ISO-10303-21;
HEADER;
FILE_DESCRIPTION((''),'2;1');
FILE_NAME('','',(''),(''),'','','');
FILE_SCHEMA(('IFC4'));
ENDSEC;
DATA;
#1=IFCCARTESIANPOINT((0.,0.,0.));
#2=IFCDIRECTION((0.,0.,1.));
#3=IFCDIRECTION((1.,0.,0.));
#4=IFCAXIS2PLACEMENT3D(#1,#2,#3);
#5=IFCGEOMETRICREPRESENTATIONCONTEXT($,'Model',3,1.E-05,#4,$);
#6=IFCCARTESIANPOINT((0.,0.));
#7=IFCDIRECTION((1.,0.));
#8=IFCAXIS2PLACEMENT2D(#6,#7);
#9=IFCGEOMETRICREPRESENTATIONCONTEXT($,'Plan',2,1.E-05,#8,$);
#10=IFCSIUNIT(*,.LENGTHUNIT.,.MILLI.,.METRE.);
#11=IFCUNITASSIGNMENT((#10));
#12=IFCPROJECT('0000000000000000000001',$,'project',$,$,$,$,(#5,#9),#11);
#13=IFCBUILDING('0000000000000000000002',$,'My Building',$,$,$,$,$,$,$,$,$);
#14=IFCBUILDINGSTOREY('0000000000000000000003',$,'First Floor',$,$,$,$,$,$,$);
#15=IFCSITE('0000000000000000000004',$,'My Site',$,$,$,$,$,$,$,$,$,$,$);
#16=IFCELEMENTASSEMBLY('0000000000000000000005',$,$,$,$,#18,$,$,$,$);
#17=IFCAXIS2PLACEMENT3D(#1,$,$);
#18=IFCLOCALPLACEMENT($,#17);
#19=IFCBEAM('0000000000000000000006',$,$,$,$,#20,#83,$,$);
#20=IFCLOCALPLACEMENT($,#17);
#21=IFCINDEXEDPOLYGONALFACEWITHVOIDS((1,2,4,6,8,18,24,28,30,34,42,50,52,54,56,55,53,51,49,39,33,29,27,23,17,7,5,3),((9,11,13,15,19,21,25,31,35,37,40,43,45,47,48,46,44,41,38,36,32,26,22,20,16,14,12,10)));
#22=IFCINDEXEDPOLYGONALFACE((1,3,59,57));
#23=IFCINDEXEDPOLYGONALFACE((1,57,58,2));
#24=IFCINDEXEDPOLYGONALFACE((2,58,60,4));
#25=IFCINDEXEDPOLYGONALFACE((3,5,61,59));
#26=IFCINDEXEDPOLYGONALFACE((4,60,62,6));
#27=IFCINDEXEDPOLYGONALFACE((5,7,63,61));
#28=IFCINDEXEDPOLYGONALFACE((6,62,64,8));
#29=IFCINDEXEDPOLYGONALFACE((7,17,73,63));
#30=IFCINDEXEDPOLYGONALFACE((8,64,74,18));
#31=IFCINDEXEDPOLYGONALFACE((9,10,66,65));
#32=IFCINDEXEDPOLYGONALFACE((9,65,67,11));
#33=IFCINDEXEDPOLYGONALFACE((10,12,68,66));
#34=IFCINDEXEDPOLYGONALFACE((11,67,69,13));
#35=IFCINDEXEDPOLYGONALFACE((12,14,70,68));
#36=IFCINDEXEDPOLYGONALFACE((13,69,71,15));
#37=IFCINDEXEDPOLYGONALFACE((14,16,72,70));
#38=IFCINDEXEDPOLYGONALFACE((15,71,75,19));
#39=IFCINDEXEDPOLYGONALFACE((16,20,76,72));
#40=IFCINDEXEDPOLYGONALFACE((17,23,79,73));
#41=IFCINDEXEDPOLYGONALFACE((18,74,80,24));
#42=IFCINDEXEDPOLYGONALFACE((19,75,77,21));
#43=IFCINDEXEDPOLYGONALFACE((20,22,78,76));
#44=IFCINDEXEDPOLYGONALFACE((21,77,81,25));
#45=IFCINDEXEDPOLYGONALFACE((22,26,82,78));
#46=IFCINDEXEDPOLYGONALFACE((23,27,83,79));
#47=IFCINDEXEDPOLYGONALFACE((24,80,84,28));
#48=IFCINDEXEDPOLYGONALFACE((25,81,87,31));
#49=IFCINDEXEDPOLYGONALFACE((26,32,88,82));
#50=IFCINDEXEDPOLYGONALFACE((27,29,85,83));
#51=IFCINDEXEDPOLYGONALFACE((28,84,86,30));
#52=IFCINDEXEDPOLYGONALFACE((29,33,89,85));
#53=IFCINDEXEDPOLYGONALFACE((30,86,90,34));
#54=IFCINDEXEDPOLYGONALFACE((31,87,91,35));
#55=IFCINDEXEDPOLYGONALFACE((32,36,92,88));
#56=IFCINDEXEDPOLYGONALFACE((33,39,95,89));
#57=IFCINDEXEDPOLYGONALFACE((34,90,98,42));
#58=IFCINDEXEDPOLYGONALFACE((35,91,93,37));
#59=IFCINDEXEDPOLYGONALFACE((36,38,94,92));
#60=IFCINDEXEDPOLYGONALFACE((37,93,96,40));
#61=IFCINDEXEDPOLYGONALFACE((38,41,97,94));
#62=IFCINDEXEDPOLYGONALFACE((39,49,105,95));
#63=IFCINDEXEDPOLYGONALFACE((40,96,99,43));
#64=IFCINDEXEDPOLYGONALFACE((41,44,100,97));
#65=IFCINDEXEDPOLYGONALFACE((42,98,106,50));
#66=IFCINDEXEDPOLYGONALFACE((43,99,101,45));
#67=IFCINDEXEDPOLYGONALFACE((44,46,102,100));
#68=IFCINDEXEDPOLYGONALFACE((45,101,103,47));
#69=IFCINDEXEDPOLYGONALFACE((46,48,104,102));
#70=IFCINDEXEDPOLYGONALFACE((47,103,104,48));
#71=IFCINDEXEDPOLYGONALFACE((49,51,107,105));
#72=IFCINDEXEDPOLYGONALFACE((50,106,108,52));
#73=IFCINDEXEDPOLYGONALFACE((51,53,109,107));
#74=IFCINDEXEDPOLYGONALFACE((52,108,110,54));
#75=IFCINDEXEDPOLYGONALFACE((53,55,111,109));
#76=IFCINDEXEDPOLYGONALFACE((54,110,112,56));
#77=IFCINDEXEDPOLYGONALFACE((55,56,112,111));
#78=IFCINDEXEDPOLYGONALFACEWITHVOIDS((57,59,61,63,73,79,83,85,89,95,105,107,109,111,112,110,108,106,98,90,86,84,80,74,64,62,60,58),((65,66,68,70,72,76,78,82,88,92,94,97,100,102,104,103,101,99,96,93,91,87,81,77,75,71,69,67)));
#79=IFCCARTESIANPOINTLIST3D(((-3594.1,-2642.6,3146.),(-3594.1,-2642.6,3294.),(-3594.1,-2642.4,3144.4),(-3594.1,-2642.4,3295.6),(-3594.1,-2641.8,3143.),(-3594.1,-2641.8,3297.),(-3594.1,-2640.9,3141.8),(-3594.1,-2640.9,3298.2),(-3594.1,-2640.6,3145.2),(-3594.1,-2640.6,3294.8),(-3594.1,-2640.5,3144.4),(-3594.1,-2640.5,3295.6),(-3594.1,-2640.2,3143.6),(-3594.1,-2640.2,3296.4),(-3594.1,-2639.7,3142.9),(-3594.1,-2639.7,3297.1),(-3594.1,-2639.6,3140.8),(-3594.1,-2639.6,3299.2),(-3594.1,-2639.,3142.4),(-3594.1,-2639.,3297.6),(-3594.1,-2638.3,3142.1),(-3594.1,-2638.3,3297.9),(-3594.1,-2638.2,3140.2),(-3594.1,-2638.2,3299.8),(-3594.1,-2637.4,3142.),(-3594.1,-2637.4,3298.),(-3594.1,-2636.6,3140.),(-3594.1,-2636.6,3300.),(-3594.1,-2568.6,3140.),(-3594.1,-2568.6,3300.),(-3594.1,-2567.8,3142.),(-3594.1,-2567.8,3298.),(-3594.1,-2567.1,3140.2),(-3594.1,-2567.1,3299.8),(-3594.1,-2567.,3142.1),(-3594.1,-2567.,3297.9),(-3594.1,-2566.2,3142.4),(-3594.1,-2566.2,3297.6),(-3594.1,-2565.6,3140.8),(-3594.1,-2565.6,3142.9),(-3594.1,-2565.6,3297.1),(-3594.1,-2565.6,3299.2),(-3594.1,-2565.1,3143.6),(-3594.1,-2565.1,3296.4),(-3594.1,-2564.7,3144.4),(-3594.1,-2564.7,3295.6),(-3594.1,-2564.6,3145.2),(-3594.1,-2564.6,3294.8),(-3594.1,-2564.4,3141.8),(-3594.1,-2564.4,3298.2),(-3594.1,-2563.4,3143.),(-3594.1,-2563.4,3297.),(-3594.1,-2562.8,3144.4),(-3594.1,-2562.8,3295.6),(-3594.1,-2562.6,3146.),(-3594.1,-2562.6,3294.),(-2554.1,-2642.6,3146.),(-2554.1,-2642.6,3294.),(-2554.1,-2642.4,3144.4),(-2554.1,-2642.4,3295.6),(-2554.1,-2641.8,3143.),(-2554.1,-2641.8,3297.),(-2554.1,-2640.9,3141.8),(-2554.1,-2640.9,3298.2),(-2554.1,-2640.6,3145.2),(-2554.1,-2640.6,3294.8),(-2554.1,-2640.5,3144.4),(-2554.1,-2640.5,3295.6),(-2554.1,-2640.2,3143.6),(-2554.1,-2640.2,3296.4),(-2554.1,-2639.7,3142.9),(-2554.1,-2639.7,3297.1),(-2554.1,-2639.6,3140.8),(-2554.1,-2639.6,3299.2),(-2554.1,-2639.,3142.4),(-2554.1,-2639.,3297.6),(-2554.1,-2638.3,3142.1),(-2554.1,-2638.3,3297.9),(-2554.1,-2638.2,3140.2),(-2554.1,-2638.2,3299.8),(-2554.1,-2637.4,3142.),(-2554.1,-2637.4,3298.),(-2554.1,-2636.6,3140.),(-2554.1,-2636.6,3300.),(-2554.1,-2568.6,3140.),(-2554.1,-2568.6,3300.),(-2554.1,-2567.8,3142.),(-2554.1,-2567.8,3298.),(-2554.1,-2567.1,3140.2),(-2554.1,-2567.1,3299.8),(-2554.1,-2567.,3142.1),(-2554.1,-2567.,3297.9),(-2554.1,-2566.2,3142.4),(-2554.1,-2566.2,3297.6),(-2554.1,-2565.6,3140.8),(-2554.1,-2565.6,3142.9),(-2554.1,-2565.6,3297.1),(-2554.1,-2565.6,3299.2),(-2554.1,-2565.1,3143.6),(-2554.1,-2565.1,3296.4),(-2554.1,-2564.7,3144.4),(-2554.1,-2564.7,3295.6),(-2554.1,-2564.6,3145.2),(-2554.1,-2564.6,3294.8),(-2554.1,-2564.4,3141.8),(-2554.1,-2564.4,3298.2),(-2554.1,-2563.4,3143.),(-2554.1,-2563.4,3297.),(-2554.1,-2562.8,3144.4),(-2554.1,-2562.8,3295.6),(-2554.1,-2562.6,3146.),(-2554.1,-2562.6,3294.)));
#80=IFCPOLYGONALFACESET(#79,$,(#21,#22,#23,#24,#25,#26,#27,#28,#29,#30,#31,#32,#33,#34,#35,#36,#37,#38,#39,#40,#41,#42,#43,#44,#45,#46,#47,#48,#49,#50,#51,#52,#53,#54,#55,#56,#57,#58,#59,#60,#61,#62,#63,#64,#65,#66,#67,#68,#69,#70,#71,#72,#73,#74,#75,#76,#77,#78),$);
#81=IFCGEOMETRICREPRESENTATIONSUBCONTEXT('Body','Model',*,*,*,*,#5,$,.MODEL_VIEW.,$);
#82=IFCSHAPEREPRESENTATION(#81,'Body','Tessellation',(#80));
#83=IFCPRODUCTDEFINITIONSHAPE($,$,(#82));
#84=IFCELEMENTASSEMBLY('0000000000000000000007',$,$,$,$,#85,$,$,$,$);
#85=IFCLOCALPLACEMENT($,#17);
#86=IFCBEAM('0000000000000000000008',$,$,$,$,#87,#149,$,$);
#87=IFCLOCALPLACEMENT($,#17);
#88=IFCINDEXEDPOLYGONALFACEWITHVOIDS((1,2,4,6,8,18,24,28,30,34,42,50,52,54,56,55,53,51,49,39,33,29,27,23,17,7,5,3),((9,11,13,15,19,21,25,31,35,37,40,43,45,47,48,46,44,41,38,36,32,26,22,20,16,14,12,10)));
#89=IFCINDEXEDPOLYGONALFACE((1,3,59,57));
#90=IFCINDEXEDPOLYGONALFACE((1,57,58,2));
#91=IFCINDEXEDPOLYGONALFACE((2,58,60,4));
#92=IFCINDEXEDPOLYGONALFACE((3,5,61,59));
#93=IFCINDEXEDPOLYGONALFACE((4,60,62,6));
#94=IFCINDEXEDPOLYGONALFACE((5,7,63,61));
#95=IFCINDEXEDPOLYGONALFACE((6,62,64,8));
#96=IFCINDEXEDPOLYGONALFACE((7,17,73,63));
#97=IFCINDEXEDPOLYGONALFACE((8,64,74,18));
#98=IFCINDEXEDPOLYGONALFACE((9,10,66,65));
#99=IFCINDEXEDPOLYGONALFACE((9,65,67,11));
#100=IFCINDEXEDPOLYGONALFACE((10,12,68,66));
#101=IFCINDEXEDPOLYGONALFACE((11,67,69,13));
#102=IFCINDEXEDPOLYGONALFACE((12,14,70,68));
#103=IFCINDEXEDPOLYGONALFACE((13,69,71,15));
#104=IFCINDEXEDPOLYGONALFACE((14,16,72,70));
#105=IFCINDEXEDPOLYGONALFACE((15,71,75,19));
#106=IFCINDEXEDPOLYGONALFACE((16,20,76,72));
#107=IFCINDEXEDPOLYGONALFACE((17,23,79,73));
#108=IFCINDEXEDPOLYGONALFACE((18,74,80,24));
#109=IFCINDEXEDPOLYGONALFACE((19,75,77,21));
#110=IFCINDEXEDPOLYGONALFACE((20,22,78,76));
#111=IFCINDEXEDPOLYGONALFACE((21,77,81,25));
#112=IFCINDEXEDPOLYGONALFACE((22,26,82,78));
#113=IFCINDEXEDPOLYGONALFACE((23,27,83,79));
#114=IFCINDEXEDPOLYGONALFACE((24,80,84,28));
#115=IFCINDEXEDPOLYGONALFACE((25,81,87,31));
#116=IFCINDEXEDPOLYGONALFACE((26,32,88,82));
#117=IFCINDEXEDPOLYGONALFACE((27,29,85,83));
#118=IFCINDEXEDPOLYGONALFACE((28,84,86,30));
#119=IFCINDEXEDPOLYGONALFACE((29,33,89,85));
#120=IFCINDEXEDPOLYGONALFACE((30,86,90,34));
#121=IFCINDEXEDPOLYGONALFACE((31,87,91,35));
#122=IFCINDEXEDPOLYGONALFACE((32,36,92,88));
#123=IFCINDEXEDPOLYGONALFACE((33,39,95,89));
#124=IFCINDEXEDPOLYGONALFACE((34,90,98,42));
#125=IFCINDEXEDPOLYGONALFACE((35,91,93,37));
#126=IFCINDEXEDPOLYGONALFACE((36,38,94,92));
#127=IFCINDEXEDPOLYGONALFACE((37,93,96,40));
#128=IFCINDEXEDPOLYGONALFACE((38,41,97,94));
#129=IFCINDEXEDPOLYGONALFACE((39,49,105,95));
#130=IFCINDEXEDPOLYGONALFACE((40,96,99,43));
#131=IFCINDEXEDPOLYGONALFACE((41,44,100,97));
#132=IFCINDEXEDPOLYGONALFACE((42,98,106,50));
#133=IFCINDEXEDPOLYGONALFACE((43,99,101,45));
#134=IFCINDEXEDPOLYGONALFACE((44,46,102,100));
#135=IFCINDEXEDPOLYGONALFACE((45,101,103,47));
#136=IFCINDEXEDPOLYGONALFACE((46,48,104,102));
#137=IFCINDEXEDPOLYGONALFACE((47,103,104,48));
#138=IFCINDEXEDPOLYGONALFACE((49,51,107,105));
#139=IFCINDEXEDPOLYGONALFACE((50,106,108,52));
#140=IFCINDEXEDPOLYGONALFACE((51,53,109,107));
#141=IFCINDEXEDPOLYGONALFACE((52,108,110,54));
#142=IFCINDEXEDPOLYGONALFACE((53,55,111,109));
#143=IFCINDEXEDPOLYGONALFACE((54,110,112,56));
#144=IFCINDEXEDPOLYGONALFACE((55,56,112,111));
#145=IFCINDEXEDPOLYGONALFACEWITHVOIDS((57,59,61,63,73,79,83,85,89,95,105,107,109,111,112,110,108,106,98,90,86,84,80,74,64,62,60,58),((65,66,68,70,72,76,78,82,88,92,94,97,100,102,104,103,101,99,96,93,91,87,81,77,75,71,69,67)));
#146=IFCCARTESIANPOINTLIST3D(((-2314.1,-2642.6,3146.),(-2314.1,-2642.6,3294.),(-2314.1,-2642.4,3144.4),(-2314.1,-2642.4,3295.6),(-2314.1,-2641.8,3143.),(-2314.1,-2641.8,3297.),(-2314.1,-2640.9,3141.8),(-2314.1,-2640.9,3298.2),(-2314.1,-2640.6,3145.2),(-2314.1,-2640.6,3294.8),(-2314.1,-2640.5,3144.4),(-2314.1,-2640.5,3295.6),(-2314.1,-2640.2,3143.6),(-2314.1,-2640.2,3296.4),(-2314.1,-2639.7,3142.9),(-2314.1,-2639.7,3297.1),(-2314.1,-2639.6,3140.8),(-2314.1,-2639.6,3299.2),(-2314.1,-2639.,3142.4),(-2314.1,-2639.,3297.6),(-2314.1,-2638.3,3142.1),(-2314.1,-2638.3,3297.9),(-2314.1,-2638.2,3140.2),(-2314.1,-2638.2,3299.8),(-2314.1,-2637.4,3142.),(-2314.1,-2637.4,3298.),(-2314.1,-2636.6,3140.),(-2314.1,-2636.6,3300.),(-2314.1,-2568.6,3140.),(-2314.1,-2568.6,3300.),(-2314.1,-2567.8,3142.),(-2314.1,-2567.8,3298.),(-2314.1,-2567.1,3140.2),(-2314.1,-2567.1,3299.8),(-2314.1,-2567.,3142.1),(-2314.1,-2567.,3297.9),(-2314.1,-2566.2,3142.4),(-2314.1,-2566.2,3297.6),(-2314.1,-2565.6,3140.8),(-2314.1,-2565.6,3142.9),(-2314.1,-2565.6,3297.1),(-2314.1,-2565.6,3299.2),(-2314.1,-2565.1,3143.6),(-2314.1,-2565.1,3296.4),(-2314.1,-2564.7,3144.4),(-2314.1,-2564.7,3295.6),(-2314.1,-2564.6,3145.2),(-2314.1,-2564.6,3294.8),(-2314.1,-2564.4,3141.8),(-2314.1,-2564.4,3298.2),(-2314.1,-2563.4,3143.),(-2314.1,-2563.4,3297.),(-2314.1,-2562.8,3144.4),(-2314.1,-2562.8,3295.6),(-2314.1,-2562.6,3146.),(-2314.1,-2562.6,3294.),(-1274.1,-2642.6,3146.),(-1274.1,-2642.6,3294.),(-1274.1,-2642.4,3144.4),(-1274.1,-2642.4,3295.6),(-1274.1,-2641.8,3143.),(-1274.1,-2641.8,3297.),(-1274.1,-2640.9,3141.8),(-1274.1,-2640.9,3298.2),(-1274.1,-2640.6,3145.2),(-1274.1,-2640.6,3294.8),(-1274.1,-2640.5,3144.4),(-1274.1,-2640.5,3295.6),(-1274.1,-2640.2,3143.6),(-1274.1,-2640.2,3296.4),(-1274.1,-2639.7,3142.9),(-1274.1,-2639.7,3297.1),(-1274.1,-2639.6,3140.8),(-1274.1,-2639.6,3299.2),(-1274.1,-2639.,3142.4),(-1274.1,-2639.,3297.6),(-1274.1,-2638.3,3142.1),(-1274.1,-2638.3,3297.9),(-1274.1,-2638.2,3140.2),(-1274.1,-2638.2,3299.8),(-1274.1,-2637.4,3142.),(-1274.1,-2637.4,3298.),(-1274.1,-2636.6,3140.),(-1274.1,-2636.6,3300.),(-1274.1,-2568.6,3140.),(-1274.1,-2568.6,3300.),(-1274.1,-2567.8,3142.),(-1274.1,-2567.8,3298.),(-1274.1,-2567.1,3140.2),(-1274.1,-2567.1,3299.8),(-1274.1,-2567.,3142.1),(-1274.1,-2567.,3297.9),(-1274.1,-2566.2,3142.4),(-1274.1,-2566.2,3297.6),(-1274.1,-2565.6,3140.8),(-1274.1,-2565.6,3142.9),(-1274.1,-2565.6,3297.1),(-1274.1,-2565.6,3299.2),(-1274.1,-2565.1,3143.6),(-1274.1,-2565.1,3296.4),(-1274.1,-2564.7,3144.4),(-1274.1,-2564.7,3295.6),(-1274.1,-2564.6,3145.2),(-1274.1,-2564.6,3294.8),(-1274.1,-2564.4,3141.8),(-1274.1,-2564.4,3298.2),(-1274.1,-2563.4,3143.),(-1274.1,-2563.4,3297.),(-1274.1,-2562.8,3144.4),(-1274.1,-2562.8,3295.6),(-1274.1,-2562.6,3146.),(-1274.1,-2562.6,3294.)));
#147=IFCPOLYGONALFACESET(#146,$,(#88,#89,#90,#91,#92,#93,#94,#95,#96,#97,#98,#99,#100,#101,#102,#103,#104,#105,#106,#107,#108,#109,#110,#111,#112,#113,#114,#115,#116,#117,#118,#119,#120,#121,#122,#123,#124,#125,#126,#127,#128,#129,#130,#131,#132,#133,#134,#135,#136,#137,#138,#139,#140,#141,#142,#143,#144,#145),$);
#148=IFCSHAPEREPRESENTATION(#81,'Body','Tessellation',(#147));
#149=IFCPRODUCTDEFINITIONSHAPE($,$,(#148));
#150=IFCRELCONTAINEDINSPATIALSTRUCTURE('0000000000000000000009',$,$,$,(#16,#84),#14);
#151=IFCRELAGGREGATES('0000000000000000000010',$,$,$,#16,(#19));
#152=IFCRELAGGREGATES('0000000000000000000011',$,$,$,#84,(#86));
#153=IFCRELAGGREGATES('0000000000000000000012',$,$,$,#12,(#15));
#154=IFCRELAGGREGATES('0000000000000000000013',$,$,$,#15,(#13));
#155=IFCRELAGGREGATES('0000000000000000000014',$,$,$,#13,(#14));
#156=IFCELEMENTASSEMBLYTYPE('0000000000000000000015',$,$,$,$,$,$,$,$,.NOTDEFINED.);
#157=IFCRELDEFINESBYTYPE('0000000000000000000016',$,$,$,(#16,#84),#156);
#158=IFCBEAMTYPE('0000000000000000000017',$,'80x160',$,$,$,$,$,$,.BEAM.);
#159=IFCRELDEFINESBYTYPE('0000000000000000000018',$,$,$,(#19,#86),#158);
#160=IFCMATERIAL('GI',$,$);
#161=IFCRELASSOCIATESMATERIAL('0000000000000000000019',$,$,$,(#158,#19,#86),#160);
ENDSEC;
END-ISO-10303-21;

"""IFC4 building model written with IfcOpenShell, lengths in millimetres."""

from ifc_helpers import new_model, si_unit, frame, origin_with_axes, origin_2d_with_axis, place, context, subcontext, project, spatial, hollow_rectangle, extrude, material, material_profile, profile_set, profile_usage, type_object, element, aggregate, save


model = new_model("IFC4")

# Units and contexts
model_context = context("Model", 3, precision=1e-05, world=origin_with_axes())
plan_context = context("Plan", 2, precision=1e-05, world=origin_2d_with_axis())
body_context = subcontext(model_context, "Body", "Model", "MODEL_VIEW")
ifc_project = project(units=[si_unit("LENGTHUNIT", "METRE", prefix="MILLI")], contexts=[model_context, plan_context])

# Site, building, storey
site = spatial("IfcSite", under=ifc_project, Name="My Site")
building = spatial("IfcBuilding", under=site, Name="My Building")
storey = spatial("IfcBuildingStorey", under=building, Name="First Floor")

# Element assemblies, beams
element_assembly_type = type_object("IfcElementAssemblyType", PredefinedType="NOTDEFINED")
ifc_material = material(Name="GI")
ifc_material_profile = material_profile(ifc_material, hollow_rectangle(XDim=80.0, YDim=160.0, WallThickness=2.0, InnerFilletRadius=3.2, OuterFilletRadius=6.0))
ifc_profile_set = profile_set([ifc_material_profile], Name="80x160 GI Rectangular Hollow")
beam_type = type_object("IfcBeamType", Name="80x160", PredefinedType="BEAM", material=ifc_profile_set)
assembly_1_placement = place(None, frame((-3674.1, -2602.6, 3220.0), z_axis=(1.0, 0.0, 0.0), x_axis=(0.0, 1.0, 0.0)))
assembly_1 = element("IfcElementAssembly", 1, at=assembly_1_placement, inside=storey, type_object=element_assembly_type)
ifc_profile_usage_1 = profile_usage(ifc_profile_set)
beam_1_placement = place(assembly_1_placement, frame((0.0, 0.0, 80.0), z_axis=(0.0, 0.0, 1.0), x_axis=(1.0, 0.0, 0.0)))
beam_1 = element("IfcBeam", 2, at=beam_1_placement, type_object=beam_type, material=ifc_profile_usage_1, context=body_context, shape_type="SweptSolid", body=[
    extrude(hollow_rectangle(XDim=80.0, YDim=160.0, WallThickness=2.0, InnerFilletRadius=3.2, OuterFilletRadius=6.0), origin_with_axes(), (0.0, 0.0, 1.0), 1040.0),
])
aggregate(assembly_1, [beam_1])
assembly_2_placement = place(None, frame((-2394.1, -2602.6, 3220.0), z_axis=(1.0, 0.0, 0.0), x_axis=(0.0, 1.0, 0.0)))
assembly_2 = element("IfcElementAssembly", 3, at=assembly_2_placement, inside=storey, type_object=element_assembly_type)
ifc_profile_usage_2 = profile_usage(ifc_profile_set)
beam_2_placement = place(assembly_2_placement, frame((0.0, 0.0, 80.0), z_axis=(0.0, 0.0, 1.0), x_axis=(1.0, 0.0, 0.0)))
beam_2 = element("IfcBeam", 4, at=beam_2_placement, type_object=beam_type, material=ifc_profile_usage_2, context=body_context, shape_type="SweptSolid", body=[
    extrude(hollow_rectangle(XDim=80.0, YDim=160.0, WallThickness=2.0, InnerFilletRadius=3.2, OuterFilletRadius=6.0), origin_with_axes(), (0.0, 0.0, 1.0), 1040.0),
])
aggregate(assembly_2, [beam_2])

save(model, "model.ifc")
